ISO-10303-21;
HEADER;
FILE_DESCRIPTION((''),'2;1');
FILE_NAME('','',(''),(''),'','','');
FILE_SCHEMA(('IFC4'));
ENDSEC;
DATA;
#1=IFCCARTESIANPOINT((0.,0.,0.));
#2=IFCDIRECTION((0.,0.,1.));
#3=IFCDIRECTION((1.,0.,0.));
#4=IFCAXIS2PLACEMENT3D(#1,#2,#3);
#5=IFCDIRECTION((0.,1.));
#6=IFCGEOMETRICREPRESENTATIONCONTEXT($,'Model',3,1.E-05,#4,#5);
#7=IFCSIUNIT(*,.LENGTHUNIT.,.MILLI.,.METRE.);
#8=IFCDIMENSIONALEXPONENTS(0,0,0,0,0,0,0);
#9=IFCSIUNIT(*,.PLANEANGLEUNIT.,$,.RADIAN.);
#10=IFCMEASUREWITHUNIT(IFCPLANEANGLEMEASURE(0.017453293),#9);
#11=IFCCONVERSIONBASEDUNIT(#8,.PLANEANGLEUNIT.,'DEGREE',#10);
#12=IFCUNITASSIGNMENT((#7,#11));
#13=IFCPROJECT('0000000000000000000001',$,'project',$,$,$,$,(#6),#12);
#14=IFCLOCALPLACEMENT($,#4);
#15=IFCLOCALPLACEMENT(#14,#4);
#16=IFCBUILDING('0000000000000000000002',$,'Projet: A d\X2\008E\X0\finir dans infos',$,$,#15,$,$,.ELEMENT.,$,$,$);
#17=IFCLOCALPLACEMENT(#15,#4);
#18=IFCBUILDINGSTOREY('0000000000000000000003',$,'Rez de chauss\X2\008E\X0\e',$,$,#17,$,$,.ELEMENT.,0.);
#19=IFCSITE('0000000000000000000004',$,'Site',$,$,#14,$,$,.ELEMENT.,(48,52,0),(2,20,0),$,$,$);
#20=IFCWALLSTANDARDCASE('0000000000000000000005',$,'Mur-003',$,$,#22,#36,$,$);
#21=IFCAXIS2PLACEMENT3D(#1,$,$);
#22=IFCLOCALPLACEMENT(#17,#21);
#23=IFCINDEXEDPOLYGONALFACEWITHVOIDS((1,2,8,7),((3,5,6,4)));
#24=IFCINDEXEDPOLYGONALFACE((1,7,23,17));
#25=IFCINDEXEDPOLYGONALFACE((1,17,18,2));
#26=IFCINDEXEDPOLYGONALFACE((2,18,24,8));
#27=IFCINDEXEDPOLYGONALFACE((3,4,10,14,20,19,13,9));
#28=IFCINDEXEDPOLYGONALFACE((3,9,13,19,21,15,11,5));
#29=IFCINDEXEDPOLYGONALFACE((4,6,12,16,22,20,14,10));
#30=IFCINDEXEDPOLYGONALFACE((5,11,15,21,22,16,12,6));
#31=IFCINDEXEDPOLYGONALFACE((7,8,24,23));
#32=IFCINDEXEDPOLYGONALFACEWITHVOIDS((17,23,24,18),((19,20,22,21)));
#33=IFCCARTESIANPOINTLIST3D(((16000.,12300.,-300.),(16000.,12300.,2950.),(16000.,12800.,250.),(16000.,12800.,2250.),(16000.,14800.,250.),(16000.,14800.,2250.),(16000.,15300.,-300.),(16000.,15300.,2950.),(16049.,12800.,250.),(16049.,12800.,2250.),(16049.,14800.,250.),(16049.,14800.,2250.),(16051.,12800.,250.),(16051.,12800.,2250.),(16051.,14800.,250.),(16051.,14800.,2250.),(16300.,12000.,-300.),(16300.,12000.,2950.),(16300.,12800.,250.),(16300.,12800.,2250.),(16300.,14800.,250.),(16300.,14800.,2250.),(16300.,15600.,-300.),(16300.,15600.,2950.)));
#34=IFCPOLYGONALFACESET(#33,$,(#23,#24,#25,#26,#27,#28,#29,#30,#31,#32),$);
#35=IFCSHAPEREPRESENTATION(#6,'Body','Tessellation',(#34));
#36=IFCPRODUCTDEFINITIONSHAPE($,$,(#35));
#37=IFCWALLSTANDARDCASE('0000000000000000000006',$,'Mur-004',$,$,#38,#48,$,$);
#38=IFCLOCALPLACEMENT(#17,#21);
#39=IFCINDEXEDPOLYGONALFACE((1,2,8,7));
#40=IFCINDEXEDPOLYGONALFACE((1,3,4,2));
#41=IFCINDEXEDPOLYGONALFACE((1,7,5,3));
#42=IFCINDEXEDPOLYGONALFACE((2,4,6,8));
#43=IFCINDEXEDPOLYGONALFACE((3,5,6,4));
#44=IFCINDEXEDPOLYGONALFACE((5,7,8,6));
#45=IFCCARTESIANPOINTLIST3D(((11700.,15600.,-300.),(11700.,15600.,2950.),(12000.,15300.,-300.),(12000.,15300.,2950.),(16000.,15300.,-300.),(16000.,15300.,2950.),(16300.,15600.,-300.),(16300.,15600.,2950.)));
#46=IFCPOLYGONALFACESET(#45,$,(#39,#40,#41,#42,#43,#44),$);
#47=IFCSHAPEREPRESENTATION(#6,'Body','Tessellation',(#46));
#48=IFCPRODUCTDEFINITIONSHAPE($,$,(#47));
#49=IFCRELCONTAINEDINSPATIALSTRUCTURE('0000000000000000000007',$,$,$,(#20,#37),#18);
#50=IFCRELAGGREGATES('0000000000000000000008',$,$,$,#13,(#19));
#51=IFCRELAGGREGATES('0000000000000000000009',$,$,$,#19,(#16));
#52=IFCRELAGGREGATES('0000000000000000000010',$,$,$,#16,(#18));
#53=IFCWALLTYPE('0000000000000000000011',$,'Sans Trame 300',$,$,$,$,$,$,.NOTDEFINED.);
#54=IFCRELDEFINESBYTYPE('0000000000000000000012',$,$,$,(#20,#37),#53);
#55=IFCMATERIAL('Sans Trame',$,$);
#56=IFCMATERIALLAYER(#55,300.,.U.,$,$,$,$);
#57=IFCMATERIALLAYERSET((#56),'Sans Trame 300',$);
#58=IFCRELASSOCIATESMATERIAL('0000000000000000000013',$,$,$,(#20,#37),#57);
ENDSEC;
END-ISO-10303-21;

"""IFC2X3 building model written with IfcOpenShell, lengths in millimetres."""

from ifc_helpers import new_model, entity, si_unit, converted_unit, direction, frame, origin_with_axes, origin_2d_with_axis, place, context, project, spatial, polyline, rectangle, outline, extrude, material, layer, layer_set, layer_usage, type_object, element, save


model = new_model("IFC2X3")

# Units and contexts
model_context = context("Model", 3, precision=1e-05, world=origin_with_axes(), true_north=direction((0.0, 1.0)))
ifc_project = project(units=[si_unit("LENGTHUNIT", "METRE", prefix="MILLI"), converted_unit("PLANEANGLEUNIT", "DEGREE", entity("IfcPlaneAngleMeasure", 0.017453293), si_unit("PLANEANGLEUNIT", "RADIAN"), dimensions=[0, 0, 0, 0, 0, 0, 0])], contexts=[model_context])

# Site, building, storey
site_placement = place(None, origin_with_axes())
site = spatial("IfcSite", under=ifc_project, at=site_placement, Name="Site", CompositionType="ELEMENT", RefLatitude=(48, 52, 0), RefLongitude=(2, 20, 0))
building_placement = place(site_placement, origin_with_axes())
building = spatial("IfcBuilding", under=site, at=building_placement, Name="Projet: A d\u008efinir dans infos", CompositionType="ELEMENT")
storey_placement = place(building_placement, origin_with_axes())
storey = spatial("IfcBuildingStorey", under=building, at=storey_placement, Name="Rez de chauss\u008ee", CompositionType="ELEMENT", Elevation=0.0)

# Shared definitions
ifc_material_1 = material(Name="Sans Trame")
ifc_layer_1 = layer(ifc_material_1, 300.0, ventilated="UNKNOWN")
ifc_layer_set_1 = layer_set([ifc_layer_1], Name="Sans Trame 300")

# Shared definitions
wall_type_1 = type_object("IfcWallType", Name="Sans Trame 300", PredefinedType="NOTDEFINED")

# Wall, opening
ifc_layer_usage_1 = layer_usage(ifc_layer_set_1, "AXIS2", "POSITIVE", 0.0)
wall_1_placement = place(storey_placement, frame((16300.0, 12000.0, -300.0), z_axis=(0.0, 0.0, 1.0), x_axis=(0.0, 1.0, 0.0)))
wall_1 = element("IfcWallStandardCase", 1, at=wall_1_placement, inside=storey, type_object=wall_type_1, material=ifc_layer_usage_1, Name="Mur-003", context=model_context, shape_type="SweptSolid", body=[
    extrude(outline(polyline([(0.0, 0.0), (3600.0, 0.0), (3300.0, 300.0), (300.0, 300.0), (0.0, 0.0)])), origin_with_axes(), (0.0, 0.0, 1.0), 3250.0),
])
opening_1_placement = place(wall_1_placement, frame((1800.0, 0.0, 550.0), z_axis=(0.0, 0.0, 1.0), x_axis=(1.0, 0.0, 0.0)))
element("IfcOpeningElement", 2, at=opening_1_placement, cuts=wall_1, context=model_context, shape_type="SweptSolid", body=[
    extrude(rectangle(XDim=2000.0, YDim=2000.0, at=origin_2d_with_axis()), frame((0.0, -601.0, 1000.0), z_axis=(0.0, 1.0, 0.0), x_axis=(1.0, 0.0, 0.0)), (0.0, 0.0, 1.0), 852.0),
    extrude(rectangle(XDim=2000.0, YDim=2000.0, at=origin_2d_with_axis()), frame((0.0, 901.0, 1000.0), z_axis=(0.0, -1.0, 0.0), x_axis=(1.0, 0.0, 0.0)), (0.0, 0.0, 1.0), 652.0),
])

# Wall
ifc_layer_usage_2 = layer_usage(ifc_layer_set_1, "AXIS2", "POSITIVE", 0.0)
wall_2_placement = place(storey_placement, frame((16300.0, 15600.0, -300.0), z_axis=(0.0, 0.0, 1.0), x_axis=(-1.0, 0.0, 0.0)))
element("IfcWallStandardCase", 3, at=wall_2_placement, inside=storey, type_object=wall_type_1, material=ifc_layer_usage_2, Name="Mur-004", context=model_context, shape_type="SweptSolid", body=[
    extrude(outline(polyline([(0.0, 0.0), (4600.0, 0.0), (4300.0, 300.0), (300.0, 300.0), (0.0, 0.0)])), origin_with_axes(), (0.0, 0.0, 1.0), 3250.0),
])

save(model, "model.ifc")
